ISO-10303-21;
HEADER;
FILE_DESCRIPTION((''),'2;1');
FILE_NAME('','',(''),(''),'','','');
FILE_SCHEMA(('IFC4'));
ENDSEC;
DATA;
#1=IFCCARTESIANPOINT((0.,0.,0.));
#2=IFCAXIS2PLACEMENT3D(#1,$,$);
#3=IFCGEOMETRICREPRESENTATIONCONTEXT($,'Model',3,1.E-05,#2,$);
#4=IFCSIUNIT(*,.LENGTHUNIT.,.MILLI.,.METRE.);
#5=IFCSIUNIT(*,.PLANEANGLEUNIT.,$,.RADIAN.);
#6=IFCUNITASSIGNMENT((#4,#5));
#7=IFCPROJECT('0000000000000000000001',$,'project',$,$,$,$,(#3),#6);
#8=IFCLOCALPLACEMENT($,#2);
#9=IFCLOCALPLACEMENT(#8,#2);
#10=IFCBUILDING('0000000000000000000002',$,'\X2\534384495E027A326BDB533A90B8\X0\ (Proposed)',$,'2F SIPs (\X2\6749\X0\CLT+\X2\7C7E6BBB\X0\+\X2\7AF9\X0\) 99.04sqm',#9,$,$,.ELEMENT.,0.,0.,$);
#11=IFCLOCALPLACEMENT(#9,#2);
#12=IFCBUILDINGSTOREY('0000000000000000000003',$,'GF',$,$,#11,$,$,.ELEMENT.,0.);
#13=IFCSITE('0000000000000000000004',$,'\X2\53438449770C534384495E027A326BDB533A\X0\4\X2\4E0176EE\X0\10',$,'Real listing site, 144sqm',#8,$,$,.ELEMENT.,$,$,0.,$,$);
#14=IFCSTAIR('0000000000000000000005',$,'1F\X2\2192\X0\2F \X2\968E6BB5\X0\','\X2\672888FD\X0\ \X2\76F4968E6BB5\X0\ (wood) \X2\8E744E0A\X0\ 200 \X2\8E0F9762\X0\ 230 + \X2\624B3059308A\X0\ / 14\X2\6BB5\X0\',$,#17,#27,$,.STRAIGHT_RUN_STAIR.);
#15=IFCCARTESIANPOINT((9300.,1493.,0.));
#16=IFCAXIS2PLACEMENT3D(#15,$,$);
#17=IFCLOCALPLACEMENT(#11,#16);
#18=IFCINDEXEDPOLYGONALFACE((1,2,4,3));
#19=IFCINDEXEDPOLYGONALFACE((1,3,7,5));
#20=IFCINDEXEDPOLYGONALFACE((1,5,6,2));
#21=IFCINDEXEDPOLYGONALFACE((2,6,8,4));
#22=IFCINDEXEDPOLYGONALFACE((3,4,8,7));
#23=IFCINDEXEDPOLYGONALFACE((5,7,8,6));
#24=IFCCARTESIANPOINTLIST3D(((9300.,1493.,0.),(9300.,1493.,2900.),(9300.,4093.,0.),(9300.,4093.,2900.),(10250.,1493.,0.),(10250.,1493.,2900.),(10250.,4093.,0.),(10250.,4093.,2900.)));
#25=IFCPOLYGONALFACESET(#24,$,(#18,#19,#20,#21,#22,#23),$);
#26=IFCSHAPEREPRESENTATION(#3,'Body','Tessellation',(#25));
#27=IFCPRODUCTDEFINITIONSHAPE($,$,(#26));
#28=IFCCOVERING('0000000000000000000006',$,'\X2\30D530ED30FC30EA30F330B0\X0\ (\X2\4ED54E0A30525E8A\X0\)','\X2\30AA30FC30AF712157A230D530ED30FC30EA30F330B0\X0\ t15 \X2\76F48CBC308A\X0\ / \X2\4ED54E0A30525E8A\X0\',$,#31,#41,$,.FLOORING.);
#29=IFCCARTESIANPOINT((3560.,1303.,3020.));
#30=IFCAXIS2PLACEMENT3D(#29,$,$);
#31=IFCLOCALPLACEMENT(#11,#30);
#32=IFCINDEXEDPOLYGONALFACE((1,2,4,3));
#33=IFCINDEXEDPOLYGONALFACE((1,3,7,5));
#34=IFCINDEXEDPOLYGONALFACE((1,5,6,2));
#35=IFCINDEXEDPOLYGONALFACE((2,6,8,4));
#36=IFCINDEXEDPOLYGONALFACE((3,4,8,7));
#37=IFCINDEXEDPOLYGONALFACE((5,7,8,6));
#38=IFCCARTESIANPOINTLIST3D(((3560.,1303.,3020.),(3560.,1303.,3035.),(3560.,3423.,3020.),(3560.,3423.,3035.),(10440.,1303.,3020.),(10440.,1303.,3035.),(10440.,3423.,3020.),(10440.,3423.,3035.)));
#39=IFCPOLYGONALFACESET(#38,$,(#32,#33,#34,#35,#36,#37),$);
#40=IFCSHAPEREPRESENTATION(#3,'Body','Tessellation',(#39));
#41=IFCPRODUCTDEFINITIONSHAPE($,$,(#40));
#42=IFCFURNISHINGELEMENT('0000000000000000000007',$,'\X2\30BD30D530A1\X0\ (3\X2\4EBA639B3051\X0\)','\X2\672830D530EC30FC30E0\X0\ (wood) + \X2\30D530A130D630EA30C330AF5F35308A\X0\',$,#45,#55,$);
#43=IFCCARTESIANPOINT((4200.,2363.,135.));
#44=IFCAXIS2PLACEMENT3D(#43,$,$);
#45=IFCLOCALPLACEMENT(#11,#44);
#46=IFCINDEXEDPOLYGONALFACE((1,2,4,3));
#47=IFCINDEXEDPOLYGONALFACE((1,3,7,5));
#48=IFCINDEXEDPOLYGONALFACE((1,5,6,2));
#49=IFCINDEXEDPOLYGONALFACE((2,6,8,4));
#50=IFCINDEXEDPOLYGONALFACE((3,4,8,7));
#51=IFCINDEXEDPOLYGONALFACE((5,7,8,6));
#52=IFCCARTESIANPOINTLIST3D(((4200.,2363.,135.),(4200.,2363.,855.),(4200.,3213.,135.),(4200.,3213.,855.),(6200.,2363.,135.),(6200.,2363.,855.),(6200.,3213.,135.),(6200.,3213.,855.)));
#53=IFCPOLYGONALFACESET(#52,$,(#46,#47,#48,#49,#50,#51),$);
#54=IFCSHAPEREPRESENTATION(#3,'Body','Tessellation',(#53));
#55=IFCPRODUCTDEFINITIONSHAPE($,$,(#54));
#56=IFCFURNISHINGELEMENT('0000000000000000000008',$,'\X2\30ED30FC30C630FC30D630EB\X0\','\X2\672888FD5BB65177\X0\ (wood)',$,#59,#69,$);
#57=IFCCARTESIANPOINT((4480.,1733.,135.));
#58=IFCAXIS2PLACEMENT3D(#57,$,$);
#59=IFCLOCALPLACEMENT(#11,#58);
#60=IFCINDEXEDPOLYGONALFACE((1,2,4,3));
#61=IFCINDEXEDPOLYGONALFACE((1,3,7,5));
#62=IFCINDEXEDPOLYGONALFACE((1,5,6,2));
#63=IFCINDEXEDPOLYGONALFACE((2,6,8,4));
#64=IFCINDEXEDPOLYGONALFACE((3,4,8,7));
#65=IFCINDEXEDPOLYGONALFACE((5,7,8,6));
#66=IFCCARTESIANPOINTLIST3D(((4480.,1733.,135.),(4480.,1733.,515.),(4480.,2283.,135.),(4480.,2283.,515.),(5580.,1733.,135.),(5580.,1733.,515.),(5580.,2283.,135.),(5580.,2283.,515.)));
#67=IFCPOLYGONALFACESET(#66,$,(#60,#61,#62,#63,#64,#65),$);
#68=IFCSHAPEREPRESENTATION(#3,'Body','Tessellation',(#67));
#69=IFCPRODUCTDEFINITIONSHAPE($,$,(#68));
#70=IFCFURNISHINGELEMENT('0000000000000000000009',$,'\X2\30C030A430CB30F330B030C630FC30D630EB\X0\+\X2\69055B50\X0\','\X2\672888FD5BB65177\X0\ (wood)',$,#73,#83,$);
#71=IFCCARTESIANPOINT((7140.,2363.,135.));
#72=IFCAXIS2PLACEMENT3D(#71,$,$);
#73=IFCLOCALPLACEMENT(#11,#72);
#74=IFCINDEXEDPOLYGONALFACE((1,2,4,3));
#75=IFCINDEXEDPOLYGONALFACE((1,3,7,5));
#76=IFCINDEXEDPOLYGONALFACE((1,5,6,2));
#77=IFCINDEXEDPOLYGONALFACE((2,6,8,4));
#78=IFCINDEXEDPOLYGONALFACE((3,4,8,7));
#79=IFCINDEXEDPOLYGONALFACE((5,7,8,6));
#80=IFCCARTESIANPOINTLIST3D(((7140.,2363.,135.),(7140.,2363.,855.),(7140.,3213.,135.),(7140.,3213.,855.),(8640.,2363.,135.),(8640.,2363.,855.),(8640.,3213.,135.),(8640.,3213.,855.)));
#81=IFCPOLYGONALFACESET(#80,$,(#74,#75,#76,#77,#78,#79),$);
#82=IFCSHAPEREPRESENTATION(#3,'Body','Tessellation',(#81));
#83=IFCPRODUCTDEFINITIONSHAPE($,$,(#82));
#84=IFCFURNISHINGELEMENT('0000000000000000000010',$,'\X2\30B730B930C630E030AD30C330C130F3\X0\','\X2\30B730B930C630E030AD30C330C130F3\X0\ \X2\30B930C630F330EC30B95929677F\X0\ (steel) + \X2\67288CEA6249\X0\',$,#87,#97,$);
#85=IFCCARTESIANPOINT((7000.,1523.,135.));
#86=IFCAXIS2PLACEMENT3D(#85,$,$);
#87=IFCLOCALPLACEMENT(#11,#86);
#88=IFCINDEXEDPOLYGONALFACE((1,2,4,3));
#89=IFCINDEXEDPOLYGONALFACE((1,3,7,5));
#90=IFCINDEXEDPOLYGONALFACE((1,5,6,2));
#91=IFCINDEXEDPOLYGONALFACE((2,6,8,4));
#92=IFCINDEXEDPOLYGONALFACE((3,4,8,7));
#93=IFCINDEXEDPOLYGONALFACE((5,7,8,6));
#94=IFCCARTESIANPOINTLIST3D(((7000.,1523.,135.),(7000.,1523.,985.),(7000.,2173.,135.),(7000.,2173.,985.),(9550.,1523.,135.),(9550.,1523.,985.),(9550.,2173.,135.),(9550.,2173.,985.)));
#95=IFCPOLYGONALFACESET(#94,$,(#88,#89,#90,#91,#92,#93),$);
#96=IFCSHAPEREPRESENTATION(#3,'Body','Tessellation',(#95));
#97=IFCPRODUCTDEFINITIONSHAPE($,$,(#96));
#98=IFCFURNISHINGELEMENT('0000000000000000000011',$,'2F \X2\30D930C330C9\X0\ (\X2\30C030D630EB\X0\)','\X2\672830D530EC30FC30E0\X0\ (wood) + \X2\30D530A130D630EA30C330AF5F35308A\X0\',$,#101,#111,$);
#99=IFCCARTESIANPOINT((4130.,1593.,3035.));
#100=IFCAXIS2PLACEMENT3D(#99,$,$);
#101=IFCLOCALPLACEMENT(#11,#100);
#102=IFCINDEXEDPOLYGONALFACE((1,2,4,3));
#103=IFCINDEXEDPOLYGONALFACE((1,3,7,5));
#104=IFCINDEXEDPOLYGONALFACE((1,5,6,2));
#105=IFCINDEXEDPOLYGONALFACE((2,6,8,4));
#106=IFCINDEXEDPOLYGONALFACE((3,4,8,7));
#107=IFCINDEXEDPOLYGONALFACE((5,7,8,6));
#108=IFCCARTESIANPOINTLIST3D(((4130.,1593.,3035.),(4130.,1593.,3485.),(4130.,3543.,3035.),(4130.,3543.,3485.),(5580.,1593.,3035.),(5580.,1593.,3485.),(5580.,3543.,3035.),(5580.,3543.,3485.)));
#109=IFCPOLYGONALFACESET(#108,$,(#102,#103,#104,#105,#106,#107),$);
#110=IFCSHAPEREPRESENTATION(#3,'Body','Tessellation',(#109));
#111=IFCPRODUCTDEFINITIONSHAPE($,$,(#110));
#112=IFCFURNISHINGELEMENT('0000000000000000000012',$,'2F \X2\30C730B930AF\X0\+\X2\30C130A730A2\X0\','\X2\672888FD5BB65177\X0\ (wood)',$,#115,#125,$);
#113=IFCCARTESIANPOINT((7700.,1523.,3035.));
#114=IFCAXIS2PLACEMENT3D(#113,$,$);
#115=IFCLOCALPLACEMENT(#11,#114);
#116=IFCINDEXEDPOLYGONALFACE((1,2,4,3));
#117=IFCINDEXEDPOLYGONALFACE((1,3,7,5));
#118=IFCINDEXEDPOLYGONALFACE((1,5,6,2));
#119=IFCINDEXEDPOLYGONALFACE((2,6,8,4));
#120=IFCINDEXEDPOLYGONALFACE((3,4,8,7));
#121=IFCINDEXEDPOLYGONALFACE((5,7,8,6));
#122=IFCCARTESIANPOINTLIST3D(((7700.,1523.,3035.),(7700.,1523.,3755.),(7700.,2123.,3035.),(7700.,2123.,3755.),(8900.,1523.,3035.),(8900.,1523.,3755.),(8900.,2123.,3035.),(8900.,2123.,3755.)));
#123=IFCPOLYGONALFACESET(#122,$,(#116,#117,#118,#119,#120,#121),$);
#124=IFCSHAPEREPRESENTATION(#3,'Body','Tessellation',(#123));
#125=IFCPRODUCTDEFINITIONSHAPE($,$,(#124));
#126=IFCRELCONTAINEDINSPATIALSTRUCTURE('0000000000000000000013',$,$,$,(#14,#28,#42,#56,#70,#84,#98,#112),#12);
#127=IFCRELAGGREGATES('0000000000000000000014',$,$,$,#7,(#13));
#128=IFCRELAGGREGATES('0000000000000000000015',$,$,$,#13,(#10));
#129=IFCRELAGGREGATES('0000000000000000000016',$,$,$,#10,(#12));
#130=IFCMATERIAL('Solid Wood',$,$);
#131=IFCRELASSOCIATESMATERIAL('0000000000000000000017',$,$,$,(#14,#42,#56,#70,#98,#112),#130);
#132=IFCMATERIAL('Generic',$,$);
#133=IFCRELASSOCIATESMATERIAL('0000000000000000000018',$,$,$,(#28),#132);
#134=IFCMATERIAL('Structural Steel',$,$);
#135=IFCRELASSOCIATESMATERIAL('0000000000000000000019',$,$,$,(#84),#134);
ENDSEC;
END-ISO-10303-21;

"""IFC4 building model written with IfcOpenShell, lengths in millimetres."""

from ifc_helpers import new_model, si_unit, frame, frame_2d, origin, place, context, project, spatial, rectangle, extrude, material, element, save


model = new_model("IFC4")

# Units and contexts
model_context = context("Model", 3, precision=1e-05, world=origin())
ifc_project = project(units=[si_unit("LENGTHUNIT", "METRE", prefix="MILLI"), si_unit("PLANEANGLEUNIT", "RADIAN")], contexts=[model_context])

# Site, building, storey
site_placement = place(None, origin())
site = spatial("IfcSite", under=ifc_project, at=site_placement, Name="千葉県千葉市稲毛区4丁目10", ObjectType="Real listing site, 144sqm", CompositionType="ELEMENT", RefElevation=0.0)
building_placement = place(site_placement, origin())
building = spatial("IfcBuilding", under=site, at=building_placement, Name="千葉市稲毛区邸 (Proposed)", ObjectType="2F SIPs (杉CLT+籾殻+竹) 99.04sqm", CompositionType="ELEMENT", ElevationOfRefHeight=0.0, ElevationOfTerrain=0.0)
storey_placement = place(building_placement, origin())
storey = spatial("IfcBuildingStorey", under=building, at=storey_placement, Name="GF", CompositionType="ELEMENT", Elevation=0.0)

# Shared definitions
ifc_material_1 = material(Name="Solid Wood")

# Shared definitions
ifc_material_2 = material(Name="Generic")

# Stair
stair_placement = place(storey_placement, frame((9300.0, 1493.0, 0.0)))
element("IfcStair", 1, at=stair_placement, inside=storey, material=ifc_material_1, Name="1F→2F 階段", Description="木製 直階段 (wood) 蹴上 200 踏面 230 + 手すり / 14段", PredefinedType="STRAIGHT_RUN_STAIR", context=model_context, shape_type="SweptSolid", body=[
    extrude(rectangle(XDim=950.0, YDim=2600.0, at=frame_2d((475.0, 1300.0))), frame((9300.0, 1493.0, 0.0)), (0.0, 0.0, 1.0), 2900.0),
])

# Covering
covering_placement = place(storey_placement, frame((3560.0, 1303.0, 3020.0)))
element("IfcCovering", 2, at=covering_placement, inside=storey, material=ifc_material_2, Name="フローリング (仕上げ床)", Description="オーク無垢フローリング t15 直貼り / 仕上げ床", PredefinedType="FLOORING", context=model_context, shape_type="SweptSolid", body=[
    extrude(rectangle(XDim=6880.0, YDim=2120.0, at=frame_2d((3440.0, 1060.0))), frame((3560.0, 1303.0, 3020.0)), (0.0, 0.0, 1.0), 15.0),
])

# Furnishing elements
furnishing_1_placement = place(storey_placement, frame((4200.0, 2363.0, 135.0)))
element("IfcFurnishingElement", 3, at=furnishing_1_placement, inside=storey, material=ifc_material_1, Name="ソファ (3人掛け)", Description="木フレーム (wood) + ファブリック張り", context=model_context, shape_type="SweptSolid", body=[
    extrude(rectangle(XDim=2000.0, YDim=850.0, at=frame_2d((1000.0, 425.0))), frame((4200.0, 2363.0, 135.0)), (0.0, 0.0, 1.0), 720.0),
])
furnishing_2_placement = place(storey_placement, frame((4480.0, 1733.0, 135.0)))
element("IfcFurnishingElement", 4, at=furnishing_2_placement, inside=storey, material=ifc_material_1, Name="ローテーブル", Description="木製家具 (wood)", context=model_context, shape_type="SweptSolid", body=[
    extrude(rectangle(XDim=1100.0, YDim=550.0, at=frame_2d((550.0, 275.0))), frame((4480.0, 1733.0, 135.0)), (0.0, 0.0, 1.0), 380.0),
])
furnishing_3_placement = place(storey_placement, frame((7140.0, 2363.0, 135.0)))
element("IfcFurnishingElement", 5, at=furnishing_3_placement, inside=storey, material=ifc_material_1, Name="ダイニングテーブル+椅子", Description="木製家具 (wood)", context=model_context, shape_type="SweptSolid", body=[
    extrude(rectangle(XDim=1500.0, YDim=850.0, at=frame_2d((750.0, 425.0))), frame((7140.0, 2363.0, 135.0)), (0.0, 0.0, 1.0), 720.0),
])
ifc_material_3 = material(Name="Structural Steel")
furnishing_4_placement = place(storey_placement, frame((7000.0, 1523.0, 135.0)))
element("IfcFurnishingElement", 6, at=furnishing_4_placement, inside=storey, material=ifc_material_3, Name="システムキッチン", Description="システムキッチン ステンレス天板 (steel) + 木質扉", context=model_context, shape_type="SweptSolid", body=[
    extrude(rectangle(XDim=2550.0, YDim=650.0, at=frame_2d((1275.0, 325.0))), frame((7000.0, 1523.0, 135.0)), (0.0, 0.0, 1.0), 850.0),
])
furnishing_5_placement = place(storey_placement, frame((4130.0, 1593.0, 3035.0)))
element("IfcFurnishingElement", 7, at=furnishing_5_placement, inside=storey, material=ifc_material_1, Name="2F ベッド (ダブル)", Description="木フレーム (wood) + ファブリック張り", context=model_context, shape_type="SweptSolid", body=[
    extrude(rectangle(XDim=1450.0, YDim=1950.0, at=frame_2d((725.0, 975.0))), frame((4130.0, 1593.0, 3035.0)), (0.0, 0.0, 1.0), 450.0),
])
furnishing_6_placement = place(storey_placement, frame((7700.0, 1523.0, 3035.0)))
element("IfcFurnishingElement", 8, at=furnishing_6_placement, inside=storey, material=ifc_material_1, Name="2F デスク+チェア", Description="木製家具 (wood)", context=model_context, shape_type="SweptSolid", body=[
    extrude(rectangle(XDim=1200.0, YDim=600.0, at=frame_2d((600.0, 300.0))), frame((7700.0, 1523.0, 3035.0)), (0.0, 0.0, 1.0), 720.0),
])

save(model, "model.ifc")
